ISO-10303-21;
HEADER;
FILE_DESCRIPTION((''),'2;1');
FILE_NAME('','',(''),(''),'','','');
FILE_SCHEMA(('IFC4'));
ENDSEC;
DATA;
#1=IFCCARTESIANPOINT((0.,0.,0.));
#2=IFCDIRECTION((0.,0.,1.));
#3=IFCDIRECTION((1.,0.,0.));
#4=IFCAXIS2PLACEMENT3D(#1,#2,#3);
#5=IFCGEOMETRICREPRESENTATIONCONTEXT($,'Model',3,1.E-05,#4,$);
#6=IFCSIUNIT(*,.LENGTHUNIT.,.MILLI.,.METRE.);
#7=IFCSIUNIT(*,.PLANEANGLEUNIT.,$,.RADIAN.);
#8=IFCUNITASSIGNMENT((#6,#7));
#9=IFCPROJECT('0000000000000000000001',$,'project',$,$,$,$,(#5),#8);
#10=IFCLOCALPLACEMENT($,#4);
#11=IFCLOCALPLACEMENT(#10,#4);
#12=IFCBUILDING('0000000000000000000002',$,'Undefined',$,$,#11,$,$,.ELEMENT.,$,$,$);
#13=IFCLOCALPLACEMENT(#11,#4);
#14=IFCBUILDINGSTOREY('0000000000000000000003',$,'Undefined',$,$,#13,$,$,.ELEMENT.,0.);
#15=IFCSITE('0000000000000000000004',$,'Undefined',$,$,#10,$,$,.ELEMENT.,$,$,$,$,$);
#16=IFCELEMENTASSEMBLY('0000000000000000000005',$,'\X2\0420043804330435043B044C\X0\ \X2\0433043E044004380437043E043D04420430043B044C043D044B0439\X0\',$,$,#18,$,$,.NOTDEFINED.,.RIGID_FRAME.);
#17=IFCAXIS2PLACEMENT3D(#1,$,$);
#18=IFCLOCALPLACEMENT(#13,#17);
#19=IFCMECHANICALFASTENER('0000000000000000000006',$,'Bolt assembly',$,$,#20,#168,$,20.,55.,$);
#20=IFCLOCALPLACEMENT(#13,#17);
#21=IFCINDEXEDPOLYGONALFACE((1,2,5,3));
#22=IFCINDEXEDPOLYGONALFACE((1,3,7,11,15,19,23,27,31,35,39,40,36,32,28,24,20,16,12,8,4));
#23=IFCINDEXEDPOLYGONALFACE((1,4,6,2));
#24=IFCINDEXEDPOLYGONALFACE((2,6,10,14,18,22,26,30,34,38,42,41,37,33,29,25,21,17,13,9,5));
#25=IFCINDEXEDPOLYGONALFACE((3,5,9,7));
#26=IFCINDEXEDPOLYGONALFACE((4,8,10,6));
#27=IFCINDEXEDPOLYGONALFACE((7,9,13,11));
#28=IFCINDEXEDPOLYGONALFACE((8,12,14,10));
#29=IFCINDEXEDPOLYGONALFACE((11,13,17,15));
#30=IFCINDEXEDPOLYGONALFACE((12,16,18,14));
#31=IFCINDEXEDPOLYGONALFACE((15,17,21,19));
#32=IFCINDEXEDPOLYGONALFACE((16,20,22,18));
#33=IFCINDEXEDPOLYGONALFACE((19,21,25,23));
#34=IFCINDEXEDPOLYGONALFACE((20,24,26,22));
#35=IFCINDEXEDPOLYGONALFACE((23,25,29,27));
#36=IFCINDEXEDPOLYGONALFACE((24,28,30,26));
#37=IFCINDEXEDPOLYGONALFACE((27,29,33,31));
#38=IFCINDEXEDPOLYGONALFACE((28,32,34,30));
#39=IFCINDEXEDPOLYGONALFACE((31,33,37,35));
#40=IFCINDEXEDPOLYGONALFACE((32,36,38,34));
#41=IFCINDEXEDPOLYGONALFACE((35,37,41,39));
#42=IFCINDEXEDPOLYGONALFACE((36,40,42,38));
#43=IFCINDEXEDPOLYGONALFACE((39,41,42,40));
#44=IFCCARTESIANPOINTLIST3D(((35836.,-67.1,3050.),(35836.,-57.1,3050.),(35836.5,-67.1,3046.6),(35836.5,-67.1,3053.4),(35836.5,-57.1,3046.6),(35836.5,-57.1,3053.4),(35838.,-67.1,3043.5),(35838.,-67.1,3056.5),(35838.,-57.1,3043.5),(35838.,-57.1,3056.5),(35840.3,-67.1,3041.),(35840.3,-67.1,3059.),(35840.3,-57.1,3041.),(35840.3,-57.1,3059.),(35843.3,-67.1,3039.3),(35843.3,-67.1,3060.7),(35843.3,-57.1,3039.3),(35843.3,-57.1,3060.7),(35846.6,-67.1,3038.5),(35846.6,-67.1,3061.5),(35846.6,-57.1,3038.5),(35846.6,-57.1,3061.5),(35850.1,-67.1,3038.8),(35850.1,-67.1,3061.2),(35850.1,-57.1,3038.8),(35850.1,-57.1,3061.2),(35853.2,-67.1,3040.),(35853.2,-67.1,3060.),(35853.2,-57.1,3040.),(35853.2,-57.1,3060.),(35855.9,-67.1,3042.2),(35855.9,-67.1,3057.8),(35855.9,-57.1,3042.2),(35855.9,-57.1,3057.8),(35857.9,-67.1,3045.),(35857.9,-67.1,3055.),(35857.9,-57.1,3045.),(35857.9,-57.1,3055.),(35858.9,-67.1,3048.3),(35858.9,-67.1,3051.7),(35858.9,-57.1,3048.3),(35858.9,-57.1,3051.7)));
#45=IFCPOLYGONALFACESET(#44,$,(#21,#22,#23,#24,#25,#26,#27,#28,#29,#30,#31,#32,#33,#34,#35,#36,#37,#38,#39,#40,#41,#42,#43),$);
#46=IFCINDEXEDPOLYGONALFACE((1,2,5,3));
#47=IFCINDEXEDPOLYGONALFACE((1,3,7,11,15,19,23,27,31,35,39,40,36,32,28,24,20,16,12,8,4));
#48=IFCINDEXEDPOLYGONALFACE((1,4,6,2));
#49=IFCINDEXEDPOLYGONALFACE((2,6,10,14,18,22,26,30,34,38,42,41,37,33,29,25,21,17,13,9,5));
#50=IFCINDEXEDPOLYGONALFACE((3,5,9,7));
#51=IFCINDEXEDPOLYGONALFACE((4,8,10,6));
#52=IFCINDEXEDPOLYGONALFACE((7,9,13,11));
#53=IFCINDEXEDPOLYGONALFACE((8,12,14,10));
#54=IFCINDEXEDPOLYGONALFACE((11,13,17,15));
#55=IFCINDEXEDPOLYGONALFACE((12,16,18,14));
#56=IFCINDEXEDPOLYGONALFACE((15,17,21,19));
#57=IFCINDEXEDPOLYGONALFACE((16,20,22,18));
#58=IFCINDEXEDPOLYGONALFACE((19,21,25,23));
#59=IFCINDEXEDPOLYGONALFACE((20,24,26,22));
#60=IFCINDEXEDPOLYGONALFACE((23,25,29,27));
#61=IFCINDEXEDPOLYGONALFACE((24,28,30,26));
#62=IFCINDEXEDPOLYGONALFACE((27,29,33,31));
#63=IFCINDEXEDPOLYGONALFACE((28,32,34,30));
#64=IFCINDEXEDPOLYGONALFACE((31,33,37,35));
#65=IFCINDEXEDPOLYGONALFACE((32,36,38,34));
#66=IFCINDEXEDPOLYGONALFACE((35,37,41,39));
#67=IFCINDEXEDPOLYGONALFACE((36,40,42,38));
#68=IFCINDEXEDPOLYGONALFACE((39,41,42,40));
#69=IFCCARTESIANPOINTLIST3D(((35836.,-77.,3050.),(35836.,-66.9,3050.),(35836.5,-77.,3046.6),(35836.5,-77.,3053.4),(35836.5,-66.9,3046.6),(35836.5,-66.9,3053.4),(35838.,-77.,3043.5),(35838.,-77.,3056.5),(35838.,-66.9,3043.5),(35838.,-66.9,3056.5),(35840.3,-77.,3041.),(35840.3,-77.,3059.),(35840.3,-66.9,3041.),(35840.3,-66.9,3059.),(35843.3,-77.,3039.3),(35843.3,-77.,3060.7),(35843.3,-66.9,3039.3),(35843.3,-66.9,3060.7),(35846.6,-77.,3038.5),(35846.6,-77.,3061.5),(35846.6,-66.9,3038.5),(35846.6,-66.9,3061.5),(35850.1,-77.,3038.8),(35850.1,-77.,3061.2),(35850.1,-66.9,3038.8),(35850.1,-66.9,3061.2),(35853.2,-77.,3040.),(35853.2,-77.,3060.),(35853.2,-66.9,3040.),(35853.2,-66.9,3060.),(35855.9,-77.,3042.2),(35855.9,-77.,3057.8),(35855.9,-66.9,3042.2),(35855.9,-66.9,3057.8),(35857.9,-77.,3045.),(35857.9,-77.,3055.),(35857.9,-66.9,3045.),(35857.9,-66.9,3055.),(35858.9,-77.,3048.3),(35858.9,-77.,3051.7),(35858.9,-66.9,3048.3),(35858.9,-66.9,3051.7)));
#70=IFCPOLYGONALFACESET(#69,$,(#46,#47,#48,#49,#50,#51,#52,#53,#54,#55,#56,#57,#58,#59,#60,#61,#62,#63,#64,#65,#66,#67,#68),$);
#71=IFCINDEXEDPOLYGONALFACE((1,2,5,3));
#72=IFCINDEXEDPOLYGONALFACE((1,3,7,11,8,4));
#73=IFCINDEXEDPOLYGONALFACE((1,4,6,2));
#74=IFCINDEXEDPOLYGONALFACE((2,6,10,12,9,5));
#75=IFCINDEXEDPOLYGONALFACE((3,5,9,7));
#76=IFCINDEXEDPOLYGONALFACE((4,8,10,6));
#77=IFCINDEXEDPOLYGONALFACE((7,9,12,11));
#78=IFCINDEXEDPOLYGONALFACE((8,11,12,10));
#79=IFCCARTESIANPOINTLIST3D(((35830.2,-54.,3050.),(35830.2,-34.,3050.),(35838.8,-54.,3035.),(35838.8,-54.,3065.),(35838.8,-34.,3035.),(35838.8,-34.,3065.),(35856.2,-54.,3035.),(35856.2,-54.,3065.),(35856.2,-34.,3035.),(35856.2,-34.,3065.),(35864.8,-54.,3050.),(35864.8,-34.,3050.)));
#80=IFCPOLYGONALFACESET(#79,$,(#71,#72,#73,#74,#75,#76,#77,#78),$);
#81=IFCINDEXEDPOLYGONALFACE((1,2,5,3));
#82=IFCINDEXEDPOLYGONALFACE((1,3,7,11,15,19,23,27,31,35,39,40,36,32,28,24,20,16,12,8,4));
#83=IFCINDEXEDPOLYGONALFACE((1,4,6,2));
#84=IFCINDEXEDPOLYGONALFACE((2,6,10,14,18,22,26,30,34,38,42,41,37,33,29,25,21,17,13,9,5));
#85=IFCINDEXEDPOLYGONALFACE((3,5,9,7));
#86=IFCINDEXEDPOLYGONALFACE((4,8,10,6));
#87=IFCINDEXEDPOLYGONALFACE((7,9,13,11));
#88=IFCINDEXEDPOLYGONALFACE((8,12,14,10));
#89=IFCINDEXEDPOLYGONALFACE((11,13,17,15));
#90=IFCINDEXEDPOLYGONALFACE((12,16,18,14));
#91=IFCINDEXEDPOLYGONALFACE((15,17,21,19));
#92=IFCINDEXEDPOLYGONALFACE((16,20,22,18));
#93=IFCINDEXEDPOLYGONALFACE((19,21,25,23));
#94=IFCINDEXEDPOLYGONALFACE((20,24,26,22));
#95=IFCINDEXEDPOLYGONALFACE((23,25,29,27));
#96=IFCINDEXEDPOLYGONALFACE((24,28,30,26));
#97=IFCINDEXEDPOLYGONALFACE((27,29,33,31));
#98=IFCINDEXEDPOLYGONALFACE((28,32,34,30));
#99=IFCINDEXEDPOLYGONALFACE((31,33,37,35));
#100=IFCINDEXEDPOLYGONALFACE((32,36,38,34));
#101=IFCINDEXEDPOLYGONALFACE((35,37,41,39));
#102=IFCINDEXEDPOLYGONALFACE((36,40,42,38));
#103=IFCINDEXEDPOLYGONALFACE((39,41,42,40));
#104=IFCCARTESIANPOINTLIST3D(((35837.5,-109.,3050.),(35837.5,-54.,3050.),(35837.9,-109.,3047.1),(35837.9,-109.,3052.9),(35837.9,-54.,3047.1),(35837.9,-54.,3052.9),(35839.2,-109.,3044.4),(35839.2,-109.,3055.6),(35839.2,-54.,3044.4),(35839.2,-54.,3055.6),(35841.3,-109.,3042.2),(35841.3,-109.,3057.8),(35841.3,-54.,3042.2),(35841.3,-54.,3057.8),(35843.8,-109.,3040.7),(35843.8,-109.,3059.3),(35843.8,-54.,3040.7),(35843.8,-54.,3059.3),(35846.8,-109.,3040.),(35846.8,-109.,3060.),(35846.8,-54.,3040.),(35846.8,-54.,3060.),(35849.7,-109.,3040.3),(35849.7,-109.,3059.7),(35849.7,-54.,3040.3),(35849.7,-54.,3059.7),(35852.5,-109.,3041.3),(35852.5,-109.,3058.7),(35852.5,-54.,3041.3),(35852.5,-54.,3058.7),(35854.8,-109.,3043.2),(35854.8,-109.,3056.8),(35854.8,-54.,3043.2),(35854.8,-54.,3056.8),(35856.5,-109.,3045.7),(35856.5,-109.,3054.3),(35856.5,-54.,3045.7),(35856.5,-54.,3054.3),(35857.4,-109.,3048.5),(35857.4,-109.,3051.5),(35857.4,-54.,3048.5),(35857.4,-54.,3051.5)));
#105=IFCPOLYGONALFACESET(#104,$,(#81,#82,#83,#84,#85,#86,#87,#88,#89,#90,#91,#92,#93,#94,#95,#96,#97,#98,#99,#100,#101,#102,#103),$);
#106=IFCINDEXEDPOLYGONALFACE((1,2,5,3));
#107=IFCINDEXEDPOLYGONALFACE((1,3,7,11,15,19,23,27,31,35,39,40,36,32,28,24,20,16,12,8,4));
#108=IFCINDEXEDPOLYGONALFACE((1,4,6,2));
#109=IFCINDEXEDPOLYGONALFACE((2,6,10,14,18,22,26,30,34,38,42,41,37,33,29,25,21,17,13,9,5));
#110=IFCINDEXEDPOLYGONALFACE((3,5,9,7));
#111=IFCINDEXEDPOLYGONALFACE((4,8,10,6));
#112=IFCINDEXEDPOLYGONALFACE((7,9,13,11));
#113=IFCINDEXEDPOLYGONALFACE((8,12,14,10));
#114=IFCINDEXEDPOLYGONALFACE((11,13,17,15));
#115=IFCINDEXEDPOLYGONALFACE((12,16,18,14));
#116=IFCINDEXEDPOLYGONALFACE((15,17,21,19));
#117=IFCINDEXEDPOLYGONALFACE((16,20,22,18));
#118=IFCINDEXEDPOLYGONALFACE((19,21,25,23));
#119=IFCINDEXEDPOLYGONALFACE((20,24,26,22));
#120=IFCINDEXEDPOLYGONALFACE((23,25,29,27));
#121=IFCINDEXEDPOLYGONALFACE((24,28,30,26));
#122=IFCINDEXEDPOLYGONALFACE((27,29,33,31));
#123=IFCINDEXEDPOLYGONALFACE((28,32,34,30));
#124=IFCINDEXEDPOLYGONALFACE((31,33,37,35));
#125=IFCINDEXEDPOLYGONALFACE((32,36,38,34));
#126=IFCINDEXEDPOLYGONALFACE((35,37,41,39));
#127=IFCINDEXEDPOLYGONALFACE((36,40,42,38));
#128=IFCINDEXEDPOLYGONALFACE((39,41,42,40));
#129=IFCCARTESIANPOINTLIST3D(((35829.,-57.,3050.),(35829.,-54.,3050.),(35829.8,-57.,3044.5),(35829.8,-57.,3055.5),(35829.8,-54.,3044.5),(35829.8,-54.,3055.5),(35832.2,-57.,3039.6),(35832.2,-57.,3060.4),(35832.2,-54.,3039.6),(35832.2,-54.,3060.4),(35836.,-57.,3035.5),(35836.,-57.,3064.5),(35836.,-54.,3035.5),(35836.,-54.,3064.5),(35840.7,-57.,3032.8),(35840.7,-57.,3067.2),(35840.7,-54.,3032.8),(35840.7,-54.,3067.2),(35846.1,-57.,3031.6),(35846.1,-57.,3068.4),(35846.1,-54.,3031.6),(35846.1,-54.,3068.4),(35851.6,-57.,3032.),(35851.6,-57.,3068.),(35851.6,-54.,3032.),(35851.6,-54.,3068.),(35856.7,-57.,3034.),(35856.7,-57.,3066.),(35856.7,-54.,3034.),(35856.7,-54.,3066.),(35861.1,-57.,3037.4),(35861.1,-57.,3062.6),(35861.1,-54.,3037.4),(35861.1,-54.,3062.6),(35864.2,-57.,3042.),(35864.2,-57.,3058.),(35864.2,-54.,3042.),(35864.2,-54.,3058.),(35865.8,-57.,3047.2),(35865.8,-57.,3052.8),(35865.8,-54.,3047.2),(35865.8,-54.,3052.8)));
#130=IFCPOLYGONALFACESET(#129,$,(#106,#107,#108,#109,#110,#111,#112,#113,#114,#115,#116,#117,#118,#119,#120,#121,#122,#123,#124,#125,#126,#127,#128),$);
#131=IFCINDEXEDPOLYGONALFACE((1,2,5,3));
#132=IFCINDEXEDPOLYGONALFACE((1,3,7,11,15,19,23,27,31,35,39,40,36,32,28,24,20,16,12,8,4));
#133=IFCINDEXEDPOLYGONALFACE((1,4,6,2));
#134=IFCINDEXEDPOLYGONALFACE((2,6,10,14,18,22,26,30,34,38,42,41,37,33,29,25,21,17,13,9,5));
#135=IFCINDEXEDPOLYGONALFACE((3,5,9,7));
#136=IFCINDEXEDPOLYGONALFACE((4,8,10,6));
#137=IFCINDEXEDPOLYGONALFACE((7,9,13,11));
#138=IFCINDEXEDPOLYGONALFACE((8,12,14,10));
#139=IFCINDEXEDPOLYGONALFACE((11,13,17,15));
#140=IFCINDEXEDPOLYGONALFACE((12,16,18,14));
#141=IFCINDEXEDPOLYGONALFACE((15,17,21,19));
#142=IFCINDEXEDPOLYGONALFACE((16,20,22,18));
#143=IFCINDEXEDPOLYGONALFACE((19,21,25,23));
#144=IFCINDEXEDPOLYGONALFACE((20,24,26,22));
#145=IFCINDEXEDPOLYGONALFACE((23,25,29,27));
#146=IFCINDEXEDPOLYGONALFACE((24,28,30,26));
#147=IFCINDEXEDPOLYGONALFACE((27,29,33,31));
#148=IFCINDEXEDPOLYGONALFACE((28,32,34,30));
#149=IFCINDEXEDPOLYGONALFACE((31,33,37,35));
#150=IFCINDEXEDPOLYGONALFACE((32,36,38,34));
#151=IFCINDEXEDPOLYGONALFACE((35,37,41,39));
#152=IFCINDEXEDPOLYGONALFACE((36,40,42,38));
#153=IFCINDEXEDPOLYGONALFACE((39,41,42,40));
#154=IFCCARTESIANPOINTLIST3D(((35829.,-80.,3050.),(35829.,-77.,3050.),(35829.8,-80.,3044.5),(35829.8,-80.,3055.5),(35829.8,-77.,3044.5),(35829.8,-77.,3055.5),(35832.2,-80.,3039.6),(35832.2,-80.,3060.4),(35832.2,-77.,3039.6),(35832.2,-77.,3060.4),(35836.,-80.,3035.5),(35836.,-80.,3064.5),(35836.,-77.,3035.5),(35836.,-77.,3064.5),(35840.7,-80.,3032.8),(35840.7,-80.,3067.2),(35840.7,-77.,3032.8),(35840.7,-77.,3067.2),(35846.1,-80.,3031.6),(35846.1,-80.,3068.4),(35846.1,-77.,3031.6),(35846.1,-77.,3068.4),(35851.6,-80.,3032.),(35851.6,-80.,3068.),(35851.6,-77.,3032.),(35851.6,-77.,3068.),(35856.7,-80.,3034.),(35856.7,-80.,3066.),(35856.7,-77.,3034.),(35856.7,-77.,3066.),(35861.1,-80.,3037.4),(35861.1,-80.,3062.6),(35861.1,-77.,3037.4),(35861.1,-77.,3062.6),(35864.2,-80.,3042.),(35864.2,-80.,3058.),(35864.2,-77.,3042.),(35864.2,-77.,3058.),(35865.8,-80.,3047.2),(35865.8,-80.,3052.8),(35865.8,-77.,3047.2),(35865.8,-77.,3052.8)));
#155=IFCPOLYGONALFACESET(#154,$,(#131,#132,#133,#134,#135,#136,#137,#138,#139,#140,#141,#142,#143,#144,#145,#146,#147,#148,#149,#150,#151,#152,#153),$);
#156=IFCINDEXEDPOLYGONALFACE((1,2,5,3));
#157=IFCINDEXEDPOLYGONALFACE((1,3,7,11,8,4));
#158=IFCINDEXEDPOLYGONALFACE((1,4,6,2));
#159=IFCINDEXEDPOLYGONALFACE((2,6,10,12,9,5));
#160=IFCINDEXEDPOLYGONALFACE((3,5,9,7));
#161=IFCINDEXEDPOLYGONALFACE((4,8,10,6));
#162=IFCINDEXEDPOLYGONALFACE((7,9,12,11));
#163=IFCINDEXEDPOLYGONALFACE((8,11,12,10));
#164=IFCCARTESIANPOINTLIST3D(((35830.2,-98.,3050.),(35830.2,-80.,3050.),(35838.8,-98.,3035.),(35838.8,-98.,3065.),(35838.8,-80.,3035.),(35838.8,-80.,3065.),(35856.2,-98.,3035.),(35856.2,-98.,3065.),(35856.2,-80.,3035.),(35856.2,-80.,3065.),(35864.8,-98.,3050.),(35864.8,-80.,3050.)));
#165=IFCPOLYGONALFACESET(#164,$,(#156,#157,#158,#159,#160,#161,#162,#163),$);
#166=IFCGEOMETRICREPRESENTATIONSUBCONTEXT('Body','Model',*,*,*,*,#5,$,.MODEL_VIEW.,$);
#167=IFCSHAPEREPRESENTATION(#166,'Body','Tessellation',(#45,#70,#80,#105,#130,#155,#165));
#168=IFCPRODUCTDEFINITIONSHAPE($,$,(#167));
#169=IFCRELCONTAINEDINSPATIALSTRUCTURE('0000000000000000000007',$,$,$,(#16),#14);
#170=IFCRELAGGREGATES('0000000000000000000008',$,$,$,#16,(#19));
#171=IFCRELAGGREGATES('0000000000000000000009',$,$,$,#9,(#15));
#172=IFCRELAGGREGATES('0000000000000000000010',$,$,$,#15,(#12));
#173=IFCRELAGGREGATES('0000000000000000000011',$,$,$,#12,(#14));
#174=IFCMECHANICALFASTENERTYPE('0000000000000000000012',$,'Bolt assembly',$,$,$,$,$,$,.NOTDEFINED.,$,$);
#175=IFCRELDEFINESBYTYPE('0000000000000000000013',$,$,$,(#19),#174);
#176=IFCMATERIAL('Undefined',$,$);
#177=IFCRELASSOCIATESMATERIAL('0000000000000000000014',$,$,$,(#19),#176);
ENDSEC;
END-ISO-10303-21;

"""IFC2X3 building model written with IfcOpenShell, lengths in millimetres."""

from ifc_helpers import new_model, si_unit, frame, origin_with_axes, origin_2d_with_axis, place, context, subcontext, project, spatial, polyline, circle, outline, extrude, source, transform, mapped, material, type_object, element, aggregate, save


model = new_model("IFC2X3")

# Units and contexts
model_context = context("Model", 3, precision=1e-05, world=origin_with_axes())
body_context = subcontext(model_context, "Body", "Model", "MODEL_VIEW")
ifc_project = project(units=[si_unit("LENGTHUNIT", "METRE", prefix="MILLI"), si_unit("PLANEANGLEUNIT", "RADIAN")], contexts=[model_context])

# Site, building, storey
site_placement = place(None, origin_with_axes())
site = spatial("IfcSite", under=ifc_project, at=site_placement, Name="Undefined", CompositionType="ELEMENT")
building_placement = place(site_placement, origin_with_axes())
building = spatial("IfcBuilding", under=site, at=building_placement, Name="Undefined", CompositionType="ELEMENT")
storey_placement = place(building_placement, origin_with_axes())
storey = spatial("IfcBuildingStorey", under=building, at=storey_placement, Name="Undefined", CompositionType="ELEMENT", Elevation=0.0)

# Element assembly
assembly_1_placement = place(storey_placement, origin_with_axes())
assembly_1 = element("IfcElementAssembly", 1, at=assembly_1_placement, inside=storey, Name="Ригель горизонтальный", AssemblyPlace="NOTDEFINED", PredefinedType="RIGID_FRAME")

# Mechanical fastener
ifc_material_1 = material(Name="Undefined")
mechanical_fastener_type = type_object("IfcMechanicalFastenerType", Name="Bolt assembly")
shared_shape_1 = source(origin_with_axes(), body_context, "Body", "SweptSolid", [
    extrude(circle(Radius=11.5, at=origin_2d_with_axis()), frame((0.0, 0.1, 0.0), z_axis=(0.0, 1.0, 0.0), x_axis=(1.0, 0.0, 0.0)), (0.0, 0.0, 1.0), 10.0),
    extrude(circle(Radius=11.5, at=origin_2d_with_axis()), frame((0.0, 9.9, 0.0), z_axis=(0.0, 1.0, 0.0), x_axis=(1.0, 0.0, 0.0)), (0.0, 0.0, 1.0), 10.1),
    extrude(outline(polyline([(17.3, 0.0), (8.7, 15.0), (-8.7, 15.0), (-17.3, 0.0), (-8.7, -15.0), (8.7, -15.0), (17.3, 0.0)])), frame((0.0, -23.0, 0.0), z_axis=(0.0, 1.0, 0.0), x_axis=(1.0, 0.0, 0.0)), (0.0, 0.0, 1.0), 20.0),
    extrude(circle(Radius=10.0, at=origin_2d_with_axis()), frame((0.0, -3.0, 0.0), z_axis=(0.0, 1.0, 0.0), x_axis=(1.0, 0.0, 0.0)), (0.0, 0.0, 1.0), 55.0),
    extrude(circle(Radius=18.5, at=origin_2d_with_axis()), frame((0.0, -3.0, 0.0), z_axis=(0.0, 1.0, 0.0), x_axis=(1.0, 0.0, 0.0)), (0.0, 0.0, 1.0), 3.0),
    extrude(circle(Radius=18.5, at=origin_2d_with_axis()), frame((0.0, 20.0, 0.0), z_axis=(0.0, 1.0, 0.0), x_axis=(1.0, 0.0, 0.0)), (0.0, 0.0, 1.0), 3.0),
    extrude(outline(polyline([(17.3, 0.0), (8.7, 15.0), (-8.7, 15.0), (-17.3, 0.0), (-8.7, -15.0), (8.7, -15.0), (17.3, 0.0)])), frame((0.0, 23.0, 0.0), z_axis=(0.0, 1.0, 0.0), x_axis=(1.0, 0.0, 0.0)), (0.0, 0.0, 1.0), 18.0),
])
mechanical_fastener_1_placement = place(assembly_1_placement, frame((35847.5, -57.0, 3050.0), z_axis=(0.0, 0.0, 1.0), x_axis=(-1.0, 0.0, 0.0)))
mechanical_fastener_1 = element("IfcMechanicalFastener", 2, at=mechanical_fastener_1_placement, type_object=mechanical_fastener_type, material=ifc_material_1, Name="Bolt assembly", NominalDiameter=20.0, NominalLength=55.0, context=body_context, shape_type="MappedRepresentation", body=[
    mapped(shared_shape_1, transform((0.0, 0.0, 0.0))),
])
aggregate(assembly_1, [mechanical_fastener_1])

save(model, "model.ifc")
